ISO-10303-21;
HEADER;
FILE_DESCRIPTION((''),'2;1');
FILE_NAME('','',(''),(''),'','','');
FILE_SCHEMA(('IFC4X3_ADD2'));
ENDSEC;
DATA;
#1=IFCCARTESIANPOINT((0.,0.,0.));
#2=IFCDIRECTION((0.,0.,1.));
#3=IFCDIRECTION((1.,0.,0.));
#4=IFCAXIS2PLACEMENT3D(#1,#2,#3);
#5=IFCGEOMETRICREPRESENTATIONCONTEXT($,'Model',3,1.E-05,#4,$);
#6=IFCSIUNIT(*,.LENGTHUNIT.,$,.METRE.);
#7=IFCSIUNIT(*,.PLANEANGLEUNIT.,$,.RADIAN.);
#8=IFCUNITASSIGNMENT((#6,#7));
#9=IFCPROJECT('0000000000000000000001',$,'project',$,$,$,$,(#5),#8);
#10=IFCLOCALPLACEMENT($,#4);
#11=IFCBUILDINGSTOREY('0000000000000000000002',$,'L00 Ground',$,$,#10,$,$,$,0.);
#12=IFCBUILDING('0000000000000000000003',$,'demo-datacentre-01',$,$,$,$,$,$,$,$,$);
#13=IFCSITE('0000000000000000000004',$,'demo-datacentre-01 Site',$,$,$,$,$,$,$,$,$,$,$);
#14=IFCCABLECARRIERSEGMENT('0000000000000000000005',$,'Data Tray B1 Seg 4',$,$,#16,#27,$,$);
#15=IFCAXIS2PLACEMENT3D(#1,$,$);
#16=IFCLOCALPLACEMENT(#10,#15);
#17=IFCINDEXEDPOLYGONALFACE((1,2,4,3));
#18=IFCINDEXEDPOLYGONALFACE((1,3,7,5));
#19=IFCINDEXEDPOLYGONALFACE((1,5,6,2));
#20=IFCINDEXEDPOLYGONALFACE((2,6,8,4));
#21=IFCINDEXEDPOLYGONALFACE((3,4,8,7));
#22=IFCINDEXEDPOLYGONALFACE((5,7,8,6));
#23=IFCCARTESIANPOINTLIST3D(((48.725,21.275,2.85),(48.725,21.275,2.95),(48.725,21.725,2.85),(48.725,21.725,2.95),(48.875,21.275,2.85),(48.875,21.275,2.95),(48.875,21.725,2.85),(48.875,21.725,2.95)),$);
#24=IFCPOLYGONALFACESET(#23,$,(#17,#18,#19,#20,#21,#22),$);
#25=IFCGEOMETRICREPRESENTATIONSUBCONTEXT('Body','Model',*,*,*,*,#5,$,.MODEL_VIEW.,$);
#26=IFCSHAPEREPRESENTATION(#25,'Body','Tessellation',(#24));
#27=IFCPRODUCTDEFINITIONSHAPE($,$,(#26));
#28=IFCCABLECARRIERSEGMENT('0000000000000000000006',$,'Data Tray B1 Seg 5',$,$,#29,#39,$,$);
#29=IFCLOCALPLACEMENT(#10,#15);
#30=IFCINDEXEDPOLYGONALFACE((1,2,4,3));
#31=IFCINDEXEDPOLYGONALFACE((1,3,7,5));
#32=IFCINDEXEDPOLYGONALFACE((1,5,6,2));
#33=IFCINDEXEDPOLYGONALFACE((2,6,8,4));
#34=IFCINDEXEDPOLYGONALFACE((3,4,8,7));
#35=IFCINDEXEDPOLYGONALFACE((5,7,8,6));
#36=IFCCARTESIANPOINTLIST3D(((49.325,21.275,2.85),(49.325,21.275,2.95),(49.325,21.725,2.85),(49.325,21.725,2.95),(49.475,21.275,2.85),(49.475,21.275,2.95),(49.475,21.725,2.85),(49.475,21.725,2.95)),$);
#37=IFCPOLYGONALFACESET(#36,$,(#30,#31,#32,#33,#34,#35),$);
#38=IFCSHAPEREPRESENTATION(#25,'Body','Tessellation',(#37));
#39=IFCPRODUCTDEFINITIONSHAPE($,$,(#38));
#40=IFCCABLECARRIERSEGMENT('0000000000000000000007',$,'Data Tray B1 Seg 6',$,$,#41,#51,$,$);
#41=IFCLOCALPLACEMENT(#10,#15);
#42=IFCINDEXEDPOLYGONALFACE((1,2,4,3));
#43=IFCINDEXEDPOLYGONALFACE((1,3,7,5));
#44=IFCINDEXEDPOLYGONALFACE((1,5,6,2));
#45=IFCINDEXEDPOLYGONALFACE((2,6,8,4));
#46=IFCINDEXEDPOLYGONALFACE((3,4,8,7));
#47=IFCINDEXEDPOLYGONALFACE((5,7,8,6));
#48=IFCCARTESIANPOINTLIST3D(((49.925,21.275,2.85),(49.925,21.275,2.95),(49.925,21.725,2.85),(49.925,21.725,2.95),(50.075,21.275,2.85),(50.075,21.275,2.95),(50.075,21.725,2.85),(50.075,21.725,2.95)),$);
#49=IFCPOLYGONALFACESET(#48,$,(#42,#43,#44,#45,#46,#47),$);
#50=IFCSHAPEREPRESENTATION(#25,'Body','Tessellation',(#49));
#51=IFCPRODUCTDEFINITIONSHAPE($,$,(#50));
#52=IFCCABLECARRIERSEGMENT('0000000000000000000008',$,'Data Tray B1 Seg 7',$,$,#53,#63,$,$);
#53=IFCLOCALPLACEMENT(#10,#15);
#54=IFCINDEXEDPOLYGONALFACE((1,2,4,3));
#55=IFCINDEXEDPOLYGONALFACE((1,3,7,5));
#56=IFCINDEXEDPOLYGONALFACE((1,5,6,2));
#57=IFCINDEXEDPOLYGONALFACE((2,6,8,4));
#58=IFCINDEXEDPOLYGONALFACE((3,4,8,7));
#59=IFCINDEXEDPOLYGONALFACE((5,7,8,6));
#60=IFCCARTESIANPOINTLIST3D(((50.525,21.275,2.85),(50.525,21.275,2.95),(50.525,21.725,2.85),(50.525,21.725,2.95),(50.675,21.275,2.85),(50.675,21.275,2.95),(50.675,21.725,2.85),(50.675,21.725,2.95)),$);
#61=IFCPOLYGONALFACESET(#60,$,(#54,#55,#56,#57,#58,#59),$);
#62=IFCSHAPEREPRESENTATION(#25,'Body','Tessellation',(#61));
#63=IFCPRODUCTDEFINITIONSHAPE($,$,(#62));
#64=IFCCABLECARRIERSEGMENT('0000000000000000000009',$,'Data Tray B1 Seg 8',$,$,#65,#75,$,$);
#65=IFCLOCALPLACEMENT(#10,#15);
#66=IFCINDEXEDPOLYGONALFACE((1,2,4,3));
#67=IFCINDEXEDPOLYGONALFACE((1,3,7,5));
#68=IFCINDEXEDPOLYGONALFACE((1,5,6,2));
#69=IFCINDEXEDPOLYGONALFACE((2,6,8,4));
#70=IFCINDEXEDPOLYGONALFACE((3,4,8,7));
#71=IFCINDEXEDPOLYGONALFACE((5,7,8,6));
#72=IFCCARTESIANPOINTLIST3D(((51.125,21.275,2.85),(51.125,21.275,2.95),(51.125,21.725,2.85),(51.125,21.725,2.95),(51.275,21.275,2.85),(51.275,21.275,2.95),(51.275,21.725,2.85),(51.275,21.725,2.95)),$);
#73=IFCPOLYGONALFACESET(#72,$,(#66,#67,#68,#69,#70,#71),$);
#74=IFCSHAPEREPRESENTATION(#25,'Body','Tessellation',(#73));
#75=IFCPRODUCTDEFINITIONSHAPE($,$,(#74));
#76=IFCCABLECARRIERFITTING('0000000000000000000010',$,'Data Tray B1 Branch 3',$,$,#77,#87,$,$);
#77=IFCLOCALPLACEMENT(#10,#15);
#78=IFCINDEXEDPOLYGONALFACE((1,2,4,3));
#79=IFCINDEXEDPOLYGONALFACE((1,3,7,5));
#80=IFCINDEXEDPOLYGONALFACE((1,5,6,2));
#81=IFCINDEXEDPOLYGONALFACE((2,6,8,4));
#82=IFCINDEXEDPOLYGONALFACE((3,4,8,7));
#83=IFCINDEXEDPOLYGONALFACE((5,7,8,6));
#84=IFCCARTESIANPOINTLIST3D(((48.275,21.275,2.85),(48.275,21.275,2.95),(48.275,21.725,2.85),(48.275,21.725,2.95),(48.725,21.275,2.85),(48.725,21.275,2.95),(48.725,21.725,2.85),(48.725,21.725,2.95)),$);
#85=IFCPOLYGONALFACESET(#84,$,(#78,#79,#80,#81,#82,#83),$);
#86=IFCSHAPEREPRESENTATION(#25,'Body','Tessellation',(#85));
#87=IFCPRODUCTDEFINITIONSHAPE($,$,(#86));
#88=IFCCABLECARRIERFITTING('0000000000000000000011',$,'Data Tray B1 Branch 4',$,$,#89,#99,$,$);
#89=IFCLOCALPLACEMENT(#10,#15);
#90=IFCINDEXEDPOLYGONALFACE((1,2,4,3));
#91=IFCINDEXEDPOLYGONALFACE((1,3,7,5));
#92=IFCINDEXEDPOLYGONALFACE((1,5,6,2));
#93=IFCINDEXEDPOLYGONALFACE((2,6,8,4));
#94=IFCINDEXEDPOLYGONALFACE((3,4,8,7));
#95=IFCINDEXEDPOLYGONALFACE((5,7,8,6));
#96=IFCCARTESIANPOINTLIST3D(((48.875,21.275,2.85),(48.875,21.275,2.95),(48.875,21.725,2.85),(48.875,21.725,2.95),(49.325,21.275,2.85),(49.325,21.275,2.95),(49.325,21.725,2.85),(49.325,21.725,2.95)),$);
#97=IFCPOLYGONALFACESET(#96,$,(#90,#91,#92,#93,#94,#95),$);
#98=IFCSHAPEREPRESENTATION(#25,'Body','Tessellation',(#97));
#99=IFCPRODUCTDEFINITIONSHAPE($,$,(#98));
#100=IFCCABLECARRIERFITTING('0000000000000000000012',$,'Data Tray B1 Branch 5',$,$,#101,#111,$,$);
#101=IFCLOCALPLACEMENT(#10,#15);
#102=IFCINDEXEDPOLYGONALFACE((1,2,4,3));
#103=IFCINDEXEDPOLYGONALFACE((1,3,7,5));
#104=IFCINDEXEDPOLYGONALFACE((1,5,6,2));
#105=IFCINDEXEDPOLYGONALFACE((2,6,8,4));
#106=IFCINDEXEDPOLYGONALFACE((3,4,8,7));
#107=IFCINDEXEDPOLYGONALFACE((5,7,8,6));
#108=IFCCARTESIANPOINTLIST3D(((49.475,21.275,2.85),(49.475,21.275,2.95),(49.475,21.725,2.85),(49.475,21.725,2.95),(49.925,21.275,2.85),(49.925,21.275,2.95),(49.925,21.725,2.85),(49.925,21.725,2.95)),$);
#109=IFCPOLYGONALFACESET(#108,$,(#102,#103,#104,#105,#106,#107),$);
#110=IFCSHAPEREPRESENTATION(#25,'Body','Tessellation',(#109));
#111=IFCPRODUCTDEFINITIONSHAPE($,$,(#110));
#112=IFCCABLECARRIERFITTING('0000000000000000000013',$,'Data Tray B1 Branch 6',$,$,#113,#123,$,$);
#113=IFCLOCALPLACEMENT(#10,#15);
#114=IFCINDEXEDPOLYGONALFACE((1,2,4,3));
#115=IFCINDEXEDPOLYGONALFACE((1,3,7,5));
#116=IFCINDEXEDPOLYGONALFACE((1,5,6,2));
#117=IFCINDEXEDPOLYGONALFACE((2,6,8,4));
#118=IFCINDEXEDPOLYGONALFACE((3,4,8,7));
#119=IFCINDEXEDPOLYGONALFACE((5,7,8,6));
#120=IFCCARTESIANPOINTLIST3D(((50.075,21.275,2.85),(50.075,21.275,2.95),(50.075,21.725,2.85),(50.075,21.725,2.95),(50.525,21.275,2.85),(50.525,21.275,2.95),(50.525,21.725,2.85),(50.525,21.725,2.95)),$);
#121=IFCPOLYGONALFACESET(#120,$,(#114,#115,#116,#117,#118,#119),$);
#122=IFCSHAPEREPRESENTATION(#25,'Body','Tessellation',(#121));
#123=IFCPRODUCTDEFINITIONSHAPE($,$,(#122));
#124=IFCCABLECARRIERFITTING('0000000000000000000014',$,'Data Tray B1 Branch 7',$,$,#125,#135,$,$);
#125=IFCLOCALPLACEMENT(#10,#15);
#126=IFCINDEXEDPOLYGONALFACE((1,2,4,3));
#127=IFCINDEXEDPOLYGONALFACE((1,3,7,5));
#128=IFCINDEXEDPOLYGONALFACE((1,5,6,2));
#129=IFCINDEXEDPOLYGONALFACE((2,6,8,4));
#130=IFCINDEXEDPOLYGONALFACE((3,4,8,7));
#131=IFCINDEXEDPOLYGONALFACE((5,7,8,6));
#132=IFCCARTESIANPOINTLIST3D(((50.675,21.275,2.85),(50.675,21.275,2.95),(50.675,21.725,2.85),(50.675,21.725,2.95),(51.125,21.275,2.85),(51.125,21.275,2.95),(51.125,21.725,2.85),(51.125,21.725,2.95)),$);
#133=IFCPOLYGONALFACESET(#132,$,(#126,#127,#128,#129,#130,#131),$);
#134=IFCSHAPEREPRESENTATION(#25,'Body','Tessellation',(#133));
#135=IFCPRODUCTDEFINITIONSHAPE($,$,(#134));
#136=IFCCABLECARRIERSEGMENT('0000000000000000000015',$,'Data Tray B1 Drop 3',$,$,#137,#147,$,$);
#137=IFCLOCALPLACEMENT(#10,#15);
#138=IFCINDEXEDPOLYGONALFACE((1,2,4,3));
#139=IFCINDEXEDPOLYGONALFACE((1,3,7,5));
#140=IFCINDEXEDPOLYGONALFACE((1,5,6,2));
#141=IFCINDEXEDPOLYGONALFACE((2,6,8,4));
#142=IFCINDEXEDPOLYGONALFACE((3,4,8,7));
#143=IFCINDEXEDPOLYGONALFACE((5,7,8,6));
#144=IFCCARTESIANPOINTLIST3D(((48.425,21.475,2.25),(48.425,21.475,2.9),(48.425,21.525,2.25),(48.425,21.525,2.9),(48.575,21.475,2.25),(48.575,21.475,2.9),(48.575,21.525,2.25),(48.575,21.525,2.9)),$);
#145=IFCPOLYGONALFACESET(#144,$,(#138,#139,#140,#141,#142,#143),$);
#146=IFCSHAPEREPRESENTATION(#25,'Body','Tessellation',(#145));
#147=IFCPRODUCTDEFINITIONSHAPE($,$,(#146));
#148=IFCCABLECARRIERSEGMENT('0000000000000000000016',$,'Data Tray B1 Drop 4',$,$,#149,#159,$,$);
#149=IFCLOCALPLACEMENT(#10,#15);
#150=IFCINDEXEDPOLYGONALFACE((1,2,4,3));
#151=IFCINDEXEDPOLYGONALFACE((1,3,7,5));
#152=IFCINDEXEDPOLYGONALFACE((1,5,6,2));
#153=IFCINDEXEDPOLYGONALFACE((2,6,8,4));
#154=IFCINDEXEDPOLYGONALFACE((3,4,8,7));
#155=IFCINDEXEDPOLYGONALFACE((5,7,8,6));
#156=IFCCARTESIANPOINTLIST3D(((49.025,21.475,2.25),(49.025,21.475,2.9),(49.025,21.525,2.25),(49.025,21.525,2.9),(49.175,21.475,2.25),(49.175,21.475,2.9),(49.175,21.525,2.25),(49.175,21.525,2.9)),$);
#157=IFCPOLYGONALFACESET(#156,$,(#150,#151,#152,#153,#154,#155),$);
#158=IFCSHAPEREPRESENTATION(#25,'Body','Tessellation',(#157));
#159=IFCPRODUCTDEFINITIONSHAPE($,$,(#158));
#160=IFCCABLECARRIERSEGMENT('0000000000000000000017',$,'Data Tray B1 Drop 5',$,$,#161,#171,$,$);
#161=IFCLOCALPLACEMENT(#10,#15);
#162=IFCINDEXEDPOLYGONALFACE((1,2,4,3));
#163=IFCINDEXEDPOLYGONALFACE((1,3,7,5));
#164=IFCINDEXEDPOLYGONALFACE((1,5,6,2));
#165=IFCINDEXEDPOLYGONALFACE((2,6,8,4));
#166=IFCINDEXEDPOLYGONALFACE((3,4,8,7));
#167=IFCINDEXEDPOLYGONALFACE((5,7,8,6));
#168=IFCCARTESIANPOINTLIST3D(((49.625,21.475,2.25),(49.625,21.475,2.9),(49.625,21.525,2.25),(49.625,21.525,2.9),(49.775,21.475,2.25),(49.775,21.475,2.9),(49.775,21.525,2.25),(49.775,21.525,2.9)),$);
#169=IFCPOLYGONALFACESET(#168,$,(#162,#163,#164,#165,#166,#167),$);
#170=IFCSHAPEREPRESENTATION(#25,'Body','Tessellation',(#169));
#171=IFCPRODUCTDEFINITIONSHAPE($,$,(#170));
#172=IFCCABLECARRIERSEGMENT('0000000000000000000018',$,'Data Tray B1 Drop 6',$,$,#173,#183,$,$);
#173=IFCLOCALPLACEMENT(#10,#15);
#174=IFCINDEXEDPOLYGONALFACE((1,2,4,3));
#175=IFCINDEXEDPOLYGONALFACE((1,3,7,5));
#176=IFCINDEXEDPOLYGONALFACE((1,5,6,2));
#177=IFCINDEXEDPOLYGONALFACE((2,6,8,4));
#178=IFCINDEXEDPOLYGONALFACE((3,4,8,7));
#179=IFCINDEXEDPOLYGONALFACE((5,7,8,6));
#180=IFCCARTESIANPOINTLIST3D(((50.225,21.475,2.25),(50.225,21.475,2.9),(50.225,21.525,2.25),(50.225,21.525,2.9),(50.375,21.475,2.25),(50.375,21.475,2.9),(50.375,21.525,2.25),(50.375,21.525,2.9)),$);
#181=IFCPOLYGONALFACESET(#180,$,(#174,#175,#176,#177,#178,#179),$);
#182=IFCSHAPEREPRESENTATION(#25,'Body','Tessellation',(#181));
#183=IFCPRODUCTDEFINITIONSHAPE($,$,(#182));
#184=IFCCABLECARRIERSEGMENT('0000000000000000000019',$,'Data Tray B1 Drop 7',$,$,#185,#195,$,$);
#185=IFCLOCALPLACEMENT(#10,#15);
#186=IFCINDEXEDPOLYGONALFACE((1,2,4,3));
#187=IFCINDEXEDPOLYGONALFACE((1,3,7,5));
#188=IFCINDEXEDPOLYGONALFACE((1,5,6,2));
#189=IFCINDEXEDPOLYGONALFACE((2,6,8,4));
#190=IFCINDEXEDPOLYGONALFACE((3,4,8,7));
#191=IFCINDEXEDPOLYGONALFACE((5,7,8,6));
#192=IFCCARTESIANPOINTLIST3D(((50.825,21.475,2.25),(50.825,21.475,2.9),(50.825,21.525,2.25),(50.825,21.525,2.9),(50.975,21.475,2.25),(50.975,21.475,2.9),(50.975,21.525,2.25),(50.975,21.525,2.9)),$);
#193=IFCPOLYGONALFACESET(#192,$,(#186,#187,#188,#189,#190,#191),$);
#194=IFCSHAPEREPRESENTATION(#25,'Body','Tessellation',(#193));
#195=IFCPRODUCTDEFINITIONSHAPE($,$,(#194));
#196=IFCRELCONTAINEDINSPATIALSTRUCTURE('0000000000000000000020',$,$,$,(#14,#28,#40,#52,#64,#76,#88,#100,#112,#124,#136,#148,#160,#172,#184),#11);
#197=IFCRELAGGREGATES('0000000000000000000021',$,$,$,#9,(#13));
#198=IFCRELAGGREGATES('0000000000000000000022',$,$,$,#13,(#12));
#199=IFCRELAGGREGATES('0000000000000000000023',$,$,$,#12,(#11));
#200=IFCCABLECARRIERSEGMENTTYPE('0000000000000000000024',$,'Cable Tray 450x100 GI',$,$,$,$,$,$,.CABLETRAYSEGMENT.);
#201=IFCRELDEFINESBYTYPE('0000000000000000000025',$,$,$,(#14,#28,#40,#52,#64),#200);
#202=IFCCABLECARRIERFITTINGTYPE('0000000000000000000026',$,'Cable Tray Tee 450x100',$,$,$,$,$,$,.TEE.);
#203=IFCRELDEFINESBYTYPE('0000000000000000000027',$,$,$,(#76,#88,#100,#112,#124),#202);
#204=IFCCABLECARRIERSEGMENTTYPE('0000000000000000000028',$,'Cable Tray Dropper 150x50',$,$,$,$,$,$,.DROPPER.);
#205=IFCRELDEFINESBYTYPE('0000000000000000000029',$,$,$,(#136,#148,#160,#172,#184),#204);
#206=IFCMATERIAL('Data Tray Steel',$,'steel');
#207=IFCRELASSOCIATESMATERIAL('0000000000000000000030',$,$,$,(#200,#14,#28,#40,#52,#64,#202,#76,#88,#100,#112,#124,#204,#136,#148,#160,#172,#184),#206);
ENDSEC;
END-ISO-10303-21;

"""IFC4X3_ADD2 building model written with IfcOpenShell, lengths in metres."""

from ifc_helpers import new_model, si_unit, frame, origin_with_axes, place, context, subcontext, project, spatial, rectangle, extrude, material, type_object, element, save


model = new_model("IFC4X3_ADD2")

# Units and contexts
model_context = context("Model", 3, precision=1e-05, world=origin_with_axes())
body_context = subcontext(model_context, "Body", "Model", "MODEL_VIEW")
ifc_project = project(units=[si_unit("LENGTHUNIT", "METRE"), si_unit("PLANEANGLEUNIT", "RADIAN")], contexts=[model_context])

# Site, building, storey
site = spatial("IfcSite", under=ifc_project, Name="demo-datacentre-01 Site")
building = spatial("IfcBuilding", under=site, Name="demo-datacentre-01")
storey_placement = place(None, origin_with_axes())
storey = spatial("IfcBuildingStorey", under=building, at=storey_placement, Name="L00 Ground", Elevation=0.0)

# Cable carrier segments
ifc_material_1 = material(Name="Data Tray Steel", Category="steel")
cable_carrier_segment_type_1 = type_object("IfcCableCarrierSegmentType", Name="Cable Tray 450x100 GI", PredefinedType="CABLETRAYSEGMENT", material=ifc_material_1)
cable_carrier_segment_placement = place(storey_placement, frame((48.725, 21.5, 2.9), z_axis=(1.0, 0.0, 0.0), x_axis=(0.0, 1.0, 0.0)))
element("IfcCableCarrierSegment", 1, at=cable_carrier_segment_placement, inside=storey, type_object=cable_carrier_segment_type_1, material=ifc_material_1, Name="Data Tray B1 Seg 4", context=body_context, shape_type="SweptSolid", body=[
    extrude(rectangle(XDim=0.45, YDim=0.1), origin_with_axes(), (0.0, 0.0, 1.0), 0.15),
])
for number, where, z_axis, x_axis, name in (
    (2, (49.325, 21.5, 2.9), (1.0, 0.0, 0.0), (0.0, 1.0, 0.0), "Data Tray B1 Seg 5"),
    (3, (49.925, 21.5, 2.9), (1.0, 0.0, 0.0), (0.0, 1.0, 0.0), "Data Tray B1 Seg 6"),
    (4, (50.525, 21.5, 2.9), (1.0, 0.0, 0.0), (0.0, 1.0, 0.0), "Data Tray B1 Seg 7"),
    (5, (51.125, 21.5, 2.9), (1.0, 0.0, 0.0), (0.0, 1.0, 0.0), "Data Tray B1 Seg 8"),
):
    element("IfcCableCarrierSegment", number, at=place(storey_placement, frame(where, z_axis=z_axis, x_axis=x_axis)), inside=storey, type_object=cable_carrier_segment_type_1, material=ifc_material_1, Name=name, context=body_context, shape_type="SweptSolid", body=[
        extrude(rectangle(XDim=0.45, YDim=0.1), origin_with_axes(), (0.0, 0.0, 1.0), 0.15),
    ])

# Cable carrier fittings
cable_carrier_fitting_type = type_object("IfcCableCarrierFittingType", Name="Cable Tray Tee 450x100", PredefinedType="TEE", material=ifc_material_1)
for number, where, z_axis, x_axis, name in (
    (6, (48.5, 21.5, 2.85), (0.0, 0.0, 1.0), (1.0, 0.0, 0.0), "Data Tray B1 Branch 3"),
    (7, (49.1, 21.5, 2.85), (0.0, 0.0, 1.0), (1.0, 0.0, 0.0), "Data Tray B1 Branch 4"),
    (8, (49.7, 21.5, 2.85), (0.0, 0.0, 1.0), (1.0, 0.0, 0.0), "Data Tray B1 Branch 5"),
    (9, (50.3, 21.5, 2.85), (0.0, 0.0, 1.0), (1.0, 0.0, 0.0), "Data Tray B1 Branch 6"),
    (10, (50.9, 21.5, 2.85), (0.0, 0.0, 1.0), (1.0, 0.0, 0.0), "Data Tray B1 Branch 7"),
):
    element("IfcCableCarrierFitting", number, at=place(storey_placement, frame(where, z_axis=z_axis, x_axis=x_axis)), inside=storey, type_object=cable_carrier_fitting_type, material=ifc_material_1, Name=name, context=body_context, shape_type="SweptSolid", body=[
        extrude(rectangle(XDim=0.45, YDim=0.45), origin_with_axes(), (0.0, 0.0, 1.0), 0.1),
    ])

# Cable carrier segments
cable_carrier_segment_type_2 = type_object("IfcCableCarrierSegmentType", Name="Cable Tray Dropper 150x50", PredefinedType="DROPPER", material=ifc_material_1)
for number, where, z_axis, x_axis, name in (
    (11, (48.5, 21.5, 2.9), (0.0, 0.0, -1.0), (1.0, 0.0, 0.0), "Data Tray B1 Drop 3"),
    (12, (49.1, 21.5, 2.9), (0.0, 0.0, -1.0), (1.0, 0.0, 0.0), "Data Tray B1 Drop 4"),
    (13, (49.7, 21.5, 2.9), (0.0, 0.0, -1.0), (1.0, 0.0, 0.0), "Data Tray B1 Drop 5"),
    (14, (50.3, 21.5, 2.9), (0.0, 0.0, -1.0), (1.0, 0.0, 0.0), "Data Tray B1 Drop 6"),
    (15, (50.9, 21.5, 2.9), (0.0, 0.0, -1.0), (1.0, 0.0, 0.0), "Data Tray B1 Drop 7"),
):
    element("IfcCableCarrierSegment", number, at=place(storey_placement, frame(where, z_axis=z_axis, x_axis=x_axis)), inside=storey, type_object=cable_carrier_segment_type_2, material=ifc_material_1, Name=name, context=body_context, shape_type="SweptSolid", body=[
        extrude(rectangle(XDim=0.15, YDim=0.05), origin_with_axes(), (0.0, 0.0, 1.0), 0.65),
    ])

save(model, "model.ifc")
